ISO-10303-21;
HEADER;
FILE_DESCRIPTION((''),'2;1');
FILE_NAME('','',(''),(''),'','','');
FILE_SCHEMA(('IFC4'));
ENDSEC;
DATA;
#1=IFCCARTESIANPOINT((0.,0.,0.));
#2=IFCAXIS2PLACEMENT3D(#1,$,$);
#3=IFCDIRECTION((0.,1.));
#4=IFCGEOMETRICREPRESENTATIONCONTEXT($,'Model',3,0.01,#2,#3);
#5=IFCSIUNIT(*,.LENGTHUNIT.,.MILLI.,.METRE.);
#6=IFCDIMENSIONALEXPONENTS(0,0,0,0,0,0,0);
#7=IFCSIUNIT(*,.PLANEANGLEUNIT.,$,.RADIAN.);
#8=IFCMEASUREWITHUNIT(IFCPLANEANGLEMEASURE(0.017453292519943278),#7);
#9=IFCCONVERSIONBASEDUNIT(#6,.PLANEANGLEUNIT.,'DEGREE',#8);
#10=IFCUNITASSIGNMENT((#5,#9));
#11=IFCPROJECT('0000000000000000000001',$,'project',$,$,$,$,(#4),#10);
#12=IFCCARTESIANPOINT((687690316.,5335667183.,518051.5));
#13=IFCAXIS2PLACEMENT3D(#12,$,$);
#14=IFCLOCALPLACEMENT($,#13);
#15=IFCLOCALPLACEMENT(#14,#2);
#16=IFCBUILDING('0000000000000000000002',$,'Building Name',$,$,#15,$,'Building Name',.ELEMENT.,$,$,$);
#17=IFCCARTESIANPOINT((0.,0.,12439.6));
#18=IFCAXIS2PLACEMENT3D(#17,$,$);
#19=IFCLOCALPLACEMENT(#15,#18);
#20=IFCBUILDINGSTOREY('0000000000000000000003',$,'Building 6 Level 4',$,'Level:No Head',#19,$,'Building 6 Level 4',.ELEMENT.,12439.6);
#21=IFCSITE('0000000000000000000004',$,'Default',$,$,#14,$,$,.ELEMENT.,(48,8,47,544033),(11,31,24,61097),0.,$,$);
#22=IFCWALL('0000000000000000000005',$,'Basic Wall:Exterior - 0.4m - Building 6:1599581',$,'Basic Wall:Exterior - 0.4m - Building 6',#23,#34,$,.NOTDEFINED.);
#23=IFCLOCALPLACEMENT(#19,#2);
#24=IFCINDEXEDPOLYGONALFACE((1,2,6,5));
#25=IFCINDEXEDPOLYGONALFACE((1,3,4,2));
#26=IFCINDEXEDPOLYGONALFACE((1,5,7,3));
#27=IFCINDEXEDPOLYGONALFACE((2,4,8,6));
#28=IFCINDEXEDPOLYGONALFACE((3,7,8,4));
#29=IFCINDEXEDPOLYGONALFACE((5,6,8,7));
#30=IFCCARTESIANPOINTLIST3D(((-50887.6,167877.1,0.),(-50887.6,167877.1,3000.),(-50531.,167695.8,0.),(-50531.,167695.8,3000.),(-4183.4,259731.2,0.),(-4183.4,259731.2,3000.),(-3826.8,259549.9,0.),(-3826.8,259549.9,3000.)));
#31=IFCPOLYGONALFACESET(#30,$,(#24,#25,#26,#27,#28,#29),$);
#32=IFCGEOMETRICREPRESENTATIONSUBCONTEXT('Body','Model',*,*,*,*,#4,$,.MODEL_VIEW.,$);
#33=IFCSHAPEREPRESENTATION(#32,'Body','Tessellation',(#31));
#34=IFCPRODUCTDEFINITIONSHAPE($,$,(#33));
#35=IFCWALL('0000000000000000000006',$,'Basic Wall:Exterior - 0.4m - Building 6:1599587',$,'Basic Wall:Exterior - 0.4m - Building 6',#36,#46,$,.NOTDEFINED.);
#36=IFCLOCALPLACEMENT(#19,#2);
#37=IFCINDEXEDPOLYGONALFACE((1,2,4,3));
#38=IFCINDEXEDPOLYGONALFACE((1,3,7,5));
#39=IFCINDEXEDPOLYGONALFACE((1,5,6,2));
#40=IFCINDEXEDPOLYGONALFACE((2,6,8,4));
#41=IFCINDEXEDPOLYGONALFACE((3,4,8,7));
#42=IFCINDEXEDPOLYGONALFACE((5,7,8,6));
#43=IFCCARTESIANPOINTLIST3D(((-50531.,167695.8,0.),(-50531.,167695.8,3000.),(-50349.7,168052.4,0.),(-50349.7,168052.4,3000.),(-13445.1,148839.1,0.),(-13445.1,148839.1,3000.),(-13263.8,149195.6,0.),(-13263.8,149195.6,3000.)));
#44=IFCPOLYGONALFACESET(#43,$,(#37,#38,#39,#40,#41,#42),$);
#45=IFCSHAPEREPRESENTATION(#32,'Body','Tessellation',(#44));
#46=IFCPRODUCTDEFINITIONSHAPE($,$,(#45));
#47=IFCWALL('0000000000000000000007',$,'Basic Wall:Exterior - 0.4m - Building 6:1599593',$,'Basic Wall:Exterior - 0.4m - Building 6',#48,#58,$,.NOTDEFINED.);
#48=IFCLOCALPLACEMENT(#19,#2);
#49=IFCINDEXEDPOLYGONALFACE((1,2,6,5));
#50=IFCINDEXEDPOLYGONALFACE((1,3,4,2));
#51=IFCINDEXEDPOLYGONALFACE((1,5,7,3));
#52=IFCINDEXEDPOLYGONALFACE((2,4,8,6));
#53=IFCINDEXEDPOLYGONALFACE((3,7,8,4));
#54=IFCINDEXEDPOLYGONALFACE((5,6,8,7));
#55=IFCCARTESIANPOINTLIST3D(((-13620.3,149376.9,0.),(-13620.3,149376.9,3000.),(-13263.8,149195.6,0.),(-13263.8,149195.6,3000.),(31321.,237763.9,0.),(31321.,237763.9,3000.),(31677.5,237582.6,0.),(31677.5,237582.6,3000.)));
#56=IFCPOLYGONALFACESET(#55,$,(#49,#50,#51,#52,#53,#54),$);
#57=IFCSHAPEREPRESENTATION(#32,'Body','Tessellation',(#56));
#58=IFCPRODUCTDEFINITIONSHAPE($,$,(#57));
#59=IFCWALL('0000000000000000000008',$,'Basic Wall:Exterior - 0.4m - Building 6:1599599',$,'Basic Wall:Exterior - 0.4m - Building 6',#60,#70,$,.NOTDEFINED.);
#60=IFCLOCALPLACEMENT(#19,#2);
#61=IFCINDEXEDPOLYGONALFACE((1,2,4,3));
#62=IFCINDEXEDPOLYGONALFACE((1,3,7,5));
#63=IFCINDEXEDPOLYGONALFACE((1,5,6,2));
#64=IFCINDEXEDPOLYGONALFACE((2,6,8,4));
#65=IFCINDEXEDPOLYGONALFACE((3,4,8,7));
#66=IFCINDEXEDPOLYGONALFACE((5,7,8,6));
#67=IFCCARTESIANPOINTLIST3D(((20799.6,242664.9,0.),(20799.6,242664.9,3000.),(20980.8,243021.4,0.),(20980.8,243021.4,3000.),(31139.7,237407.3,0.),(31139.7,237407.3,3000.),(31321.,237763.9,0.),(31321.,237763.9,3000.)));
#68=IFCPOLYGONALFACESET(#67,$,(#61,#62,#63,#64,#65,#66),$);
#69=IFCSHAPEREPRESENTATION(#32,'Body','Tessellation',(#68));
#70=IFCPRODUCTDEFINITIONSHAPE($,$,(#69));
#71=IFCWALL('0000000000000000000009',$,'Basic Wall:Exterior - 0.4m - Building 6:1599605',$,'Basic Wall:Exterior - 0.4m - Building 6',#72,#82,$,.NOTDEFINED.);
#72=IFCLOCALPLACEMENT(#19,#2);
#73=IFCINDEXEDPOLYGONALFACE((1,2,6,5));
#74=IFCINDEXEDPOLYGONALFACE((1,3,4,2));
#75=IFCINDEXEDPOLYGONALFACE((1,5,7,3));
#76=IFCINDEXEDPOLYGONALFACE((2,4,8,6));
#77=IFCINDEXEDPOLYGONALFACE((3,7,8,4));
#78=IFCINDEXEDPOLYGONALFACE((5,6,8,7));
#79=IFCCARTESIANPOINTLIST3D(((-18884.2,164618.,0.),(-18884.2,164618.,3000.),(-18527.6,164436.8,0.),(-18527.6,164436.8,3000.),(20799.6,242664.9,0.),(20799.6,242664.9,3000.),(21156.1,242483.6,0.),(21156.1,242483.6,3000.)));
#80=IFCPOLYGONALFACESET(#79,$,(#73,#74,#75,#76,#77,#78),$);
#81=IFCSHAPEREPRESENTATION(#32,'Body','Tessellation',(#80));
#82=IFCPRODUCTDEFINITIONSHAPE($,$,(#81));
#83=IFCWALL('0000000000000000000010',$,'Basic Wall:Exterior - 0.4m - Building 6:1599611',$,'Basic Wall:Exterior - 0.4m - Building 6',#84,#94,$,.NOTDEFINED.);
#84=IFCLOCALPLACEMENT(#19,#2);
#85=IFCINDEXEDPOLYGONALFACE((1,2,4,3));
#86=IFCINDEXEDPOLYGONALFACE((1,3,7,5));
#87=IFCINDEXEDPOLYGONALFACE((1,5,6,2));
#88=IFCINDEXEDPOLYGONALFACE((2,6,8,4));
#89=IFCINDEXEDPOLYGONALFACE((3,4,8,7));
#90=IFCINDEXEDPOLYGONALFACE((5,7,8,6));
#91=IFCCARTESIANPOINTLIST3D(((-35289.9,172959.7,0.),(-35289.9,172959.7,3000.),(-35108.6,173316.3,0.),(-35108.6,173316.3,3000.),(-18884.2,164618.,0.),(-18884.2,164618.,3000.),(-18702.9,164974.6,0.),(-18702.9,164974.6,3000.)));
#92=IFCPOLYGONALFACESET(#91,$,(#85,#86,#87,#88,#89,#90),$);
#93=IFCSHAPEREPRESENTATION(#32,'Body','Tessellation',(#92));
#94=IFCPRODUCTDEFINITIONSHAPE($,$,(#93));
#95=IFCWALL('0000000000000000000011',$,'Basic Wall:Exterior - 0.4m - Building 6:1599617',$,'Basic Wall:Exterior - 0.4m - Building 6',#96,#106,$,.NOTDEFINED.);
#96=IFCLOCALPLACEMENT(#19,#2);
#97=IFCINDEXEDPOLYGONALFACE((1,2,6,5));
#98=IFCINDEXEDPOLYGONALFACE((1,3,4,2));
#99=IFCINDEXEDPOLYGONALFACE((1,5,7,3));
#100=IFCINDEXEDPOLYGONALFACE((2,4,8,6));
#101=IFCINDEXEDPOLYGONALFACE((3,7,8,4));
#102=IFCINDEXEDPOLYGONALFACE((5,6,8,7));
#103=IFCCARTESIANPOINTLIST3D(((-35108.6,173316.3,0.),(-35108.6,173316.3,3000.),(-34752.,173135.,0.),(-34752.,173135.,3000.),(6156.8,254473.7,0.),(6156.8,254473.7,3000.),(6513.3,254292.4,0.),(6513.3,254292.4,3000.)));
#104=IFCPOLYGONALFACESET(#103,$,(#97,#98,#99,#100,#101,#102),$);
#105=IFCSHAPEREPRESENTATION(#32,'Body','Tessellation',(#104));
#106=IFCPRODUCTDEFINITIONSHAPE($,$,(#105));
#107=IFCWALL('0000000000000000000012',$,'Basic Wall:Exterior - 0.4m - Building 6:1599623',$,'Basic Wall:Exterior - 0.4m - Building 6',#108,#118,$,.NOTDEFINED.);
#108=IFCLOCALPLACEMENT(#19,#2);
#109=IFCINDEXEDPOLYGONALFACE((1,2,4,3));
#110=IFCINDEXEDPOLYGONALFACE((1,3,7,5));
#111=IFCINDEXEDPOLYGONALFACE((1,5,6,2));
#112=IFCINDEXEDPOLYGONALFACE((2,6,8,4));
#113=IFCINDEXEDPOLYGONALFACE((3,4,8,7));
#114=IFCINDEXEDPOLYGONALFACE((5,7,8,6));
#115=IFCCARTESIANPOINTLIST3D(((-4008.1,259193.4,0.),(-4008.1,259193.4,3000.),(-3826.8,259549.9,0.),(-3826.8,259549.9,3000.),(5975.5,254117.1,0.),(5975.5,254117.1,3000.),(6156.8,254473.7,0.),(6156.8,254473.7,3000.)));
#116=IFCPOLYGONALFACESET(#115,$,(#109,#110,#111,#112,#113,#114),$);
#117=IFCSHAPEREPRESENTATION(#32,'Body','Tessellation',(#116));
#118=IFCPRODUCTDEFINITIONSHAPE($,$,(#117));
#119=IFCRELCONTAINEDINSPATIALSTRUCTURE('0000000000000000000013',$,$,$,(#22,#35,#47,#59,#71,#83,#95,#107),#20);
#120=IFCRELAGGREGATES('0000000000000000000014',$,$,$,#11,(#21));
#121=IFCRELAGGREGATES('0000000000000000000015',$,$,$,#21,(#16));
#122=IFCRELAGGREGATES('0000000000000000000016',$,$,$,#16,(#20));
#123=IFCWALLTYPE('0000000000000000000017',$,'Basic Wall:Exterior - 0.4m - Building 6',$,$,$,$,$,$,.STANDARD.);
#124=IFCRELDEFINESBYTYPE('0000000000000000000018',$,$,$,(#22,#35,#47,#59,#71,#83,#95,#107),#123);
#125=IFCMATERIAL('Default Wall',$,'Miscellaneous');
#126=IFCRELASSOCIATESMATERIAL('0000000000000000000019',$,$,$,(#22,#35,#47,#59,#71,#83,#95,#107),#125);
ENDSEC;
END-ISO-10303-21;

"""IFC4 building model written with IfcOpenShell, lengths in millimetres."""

from ifc_helpers import new_model, entity, si_unit, converted_unit, direction, frame, origin, place, context, subcontext, project, spatial, indexed_curve, outline, extrude, material, type_object, element, save


model = new_model("IFC4")

# Units and contexts
model_context = context("Model", 3, precision=0.01, world=origin(), true_north=direction((0.0, 1.0)))
body_context = subcontext(model_context, "Body", "Model", "MODEL_VIEW")
ifc_project = project(units=[si_unit("LENGTHUNIT", "METRE", prefix="MILLI"), converted_unit("PLANEANGLEUNIT", "DEGREE", entity("IfcPlaneAngleMeasure", 0.017453292519943278), si_unit("PLANEANGLEUNIT", "RADIAN"), dimensions=[0, 0, 0, 0, 0, 0, 0])], contexts=[model_context])

# Site, building, storey
site_placement = place(None, frame((687690316.0, 5335667183.0, 518051.5)))
site = spatial("IfcSite", under=ifc_project, at=site_placement, Name="Default", CompositionType="ELEMENT", RefLatitude=(48, 8, 47, 544033), RefLongitude=(11, 31, 24, 61097), RefElevation=0.0)
building_placement = place(site_placement, origin())
building = spatial("IfcBuilding", under=site, at=building_placement, Name="Building Name", LongName="Building Name", CompositionType="ELEMENT")
storey_placement = place(building_placement, frame((0.0, 0.0, 12439.6)))
storey = spatial("IfcBuildingStorey", under=building, at=storey_placement, Name="Building 6 Level 4", ObjectType="Level:No Head", LongName="Building 6 Level 4", CompositionType="ELEMENT", Elevation=12439.6)

# Walls
ifc_material_1 = material(Name="Default Wall", Category="Miscellaneous")
wall_type = type_object("IfcWallType", Name="Basic Wall:Exterior - 0.4m - Building 6", PredefinedType="STANDARD")
wall_1_placement = place(storey_placement, frame((-4005.1, 259640.6, 0.0), z_axis=(0.0, 0.0, 1.0), x_axis=(-0.453237, -0.89139, 0.0)))
element("IfcWall", 1, at=wall_1_placement, inside=storey, type_object=wall_type, material=ifc_material_1, Name="Basic Wall:Exterior - 0.4m - Building 6:1599581", ObjectType="Basic Wall:Exterior - 0.4m - Building 6", PredefinedType="NOTDEFINED", context=body_context, shape_type="SweptSolid", body=[
    extrude(outline(indexed_curve([(103045.9, 200.0), (0.0, 200.0), (0.0, -200.0), (103045.9, -200.0), (103045.9, 200.0)], self_intersect=False)), origin(), (0.0, 0.0, 1.0), 3000.0),
])
wall_2_placement = place(storey_placement, frame((-50440.4, 167874.1, 0.0), z_axis=(0.0, 0.0, 1.0), x_axis=(0.89139, -0.453237, 0.0)))
element("IfcWall", 2, at=wall_2_placement, inside=storey, type_object=wall_type, material=ifc_material_1, Name="Basic Wall:Exterior - 0.4m - Building 6:1599587", ObjectType="Basic Wall:Exterior - 0.4m - Building 6", PredefinedType="NOTDEFINED", context=body_context, shape_type="SweptSolid", body=[
    extrude(outline(indexed_curve([(41604.6, 200.0), (0.0, 200.0), (0.0, -200.0), (41604.6, -200.0), (41604.6, 200.0)], self_intersect=False)), origin(), (0.0, 0.0, 1.0), 3000.0),
])
wall_3_placement = place(storey_placement, frame((-13442.0, 149286.3, 0.0), z_axis=(0.0, 0.0, 1.0), x_axis=(0.453237, 0.89139, 0.0)))
element("IfcWall", 3, at=wall_3_placement, inside=storey, type_object=wall_type, material=ifc_material_1, Name="Basic Wall:Exterior - 0.4m - Building 6:1599593", ObjectType="Basic Wall:Exterior - 0.4m - Building 6", PredefinedType="NOTDEFINED", context=body_context, shape_type="SweptSolid", body=[
    extrude(outline(indexed_curve([(99156.3, 200.0), (0.0, 200.0), (0.0, -200.0), (99156.3, -200.0), (99156.3, 200.0)], self_intersect=False)), origin(), (0.0, 0.0, 1.0), 3000.0),
])
wall_4_placement = place(storey_placement, frame((31230.3, 237585.6, 0.0), z_axis=(0.0, 0.0, 1.0), x_axis=(-0.89139, 0.453237, 0.0)))
element("IfcWall", 4, at=wall_4_placement, inside=storey, type_object=wall_type, material=ifc_material_1, Name="Basic Wall:Exterior - 0.4m - Building 6:1599599", ObjectType="Basic Wall:Exterior - 0.4m - Building 6", PredefinedType="NOTDEFINED", context=body_context, shape_type="SweptSolid", body=[
    extrude(outline(indexed_curve([(11600.0, 200.0), (0.0, 200.0), (0.0, -200.0), (11600.0, -200.0), (11600.0, 200.0)], self_intersect=False)), origin(), (0.0, 0.0, 1.0), 3000.0),
])
wall_5_placement = place(storey_placement, frame((20977.8, 242574.2, 0.0), z_axis=(0.0, 0.0, 1.0), x_axis=(-0.453237, -0.89139, 0.0)))
element("IfcWall", 5, at=wall_5_placement, inside=storey, type_object=wall_type, material=ifc_material_1, Name="Basic Wall:Exterior - 0.4m - Building 6:1599605", ObjectType="Basic Wall:Exterior - 0.4m - Building 6", PredefinedType="NOTDEFINED", context=body_context, shape_type="SweptSolid", body=[
    extrude(outline(indexed_curve([(87556.3, 200.0), (0.0, 200.0), (0.0, -200.0), (87556.3, -200.0), (87556.3, 200.0)], self_intersect=False)), origin(), (0.0, 0.0, 1.0), 3000.0),
])
wall_6_placement = place(storey_placement, frame((-18793.5, 164796.3, 0.0), z_axis=(0.0, 0.0, 1.0), x_axis=(-0.89139, 0.453237, 0.0)))
element("IfcWall", 6, at=wall_6_placement, inside=storey, type_object=wall_type, material=ifc_material_1, Name="Basic Wall:Exterior - 0.4m - Building 6:1599611", ObjectType="Basic Wall:Exterior - 0.4m - Building 6", PredefinedType="NOTDEFINED", context=body_context, shape_type="SweptSolid", body=[
    extrude(outline(indexed_curve([(18404.6, 200.0), (0.0, 200.0), (0.0, -200.0), (18404.6, -200.0), (18404.6, 200.0)], self_intersect=False)), origin(), (0.0, 0.0, 1.0), 3000.0),
])
wall_7_placement = place(storey_placement, frame((-34930.3, 173225.6, 0.0), z_axis=(0.0, 0.0, 1.0), x_axis=(0.453237, 0.89139, 0.0)))
element("IfcWall", 7, at=wall_7_placement, inside=storey, type_object=wall_type, material=ifc_material_1, Name="Basic Wall:Exterior - 0.4m - Building 6:1599617", ObjectType="Basic Wall:Exterior - 0.4m - Building 6", PredefinedType="NOTDEFINED", context=body_context, shape_type="SweptSolid", body=[
    extrude(outline(indexed_curve([(91045.9, 200.0), (0.0, 200.0), (0.0, -200.0), (91045.9, -200.0), (91045.9, 200.0)], self_intersect=False)), origin(), (0.0, 0.0, 1.0), 3000.0),
])
wall_8_placement = place(storey_placement, frame((6066.1, 254295.4, 0.0), z_axis=(0.0, 0.0, 1.0), x_axis=(-0.89139, 0.453237, 0.0)))
element("IfcWall", 8, at=wall_8_placement, inside=storey, type_object=wall_type, material=ifc_material_1, Name="Basic Wall:Exterior - 0.4m - Building 6:1599623", ObjectType="Basic Wall:Exterior - 0.4m - Building 6", PredefinedType="NOTDEFINED", context=body_context, shape_type="SweptSolid", body=[
    extrude(outline(indexed_curve([(11200.0, 200.0), (0.0, 200.0), (0.0, -200.0), (11200.0, -200.0), (11200.0, 200.0)], self_intersect=False)), origin(), (0.0, 0.0, 1.0), 3000.0),
])

save(model, "model.ifc")
